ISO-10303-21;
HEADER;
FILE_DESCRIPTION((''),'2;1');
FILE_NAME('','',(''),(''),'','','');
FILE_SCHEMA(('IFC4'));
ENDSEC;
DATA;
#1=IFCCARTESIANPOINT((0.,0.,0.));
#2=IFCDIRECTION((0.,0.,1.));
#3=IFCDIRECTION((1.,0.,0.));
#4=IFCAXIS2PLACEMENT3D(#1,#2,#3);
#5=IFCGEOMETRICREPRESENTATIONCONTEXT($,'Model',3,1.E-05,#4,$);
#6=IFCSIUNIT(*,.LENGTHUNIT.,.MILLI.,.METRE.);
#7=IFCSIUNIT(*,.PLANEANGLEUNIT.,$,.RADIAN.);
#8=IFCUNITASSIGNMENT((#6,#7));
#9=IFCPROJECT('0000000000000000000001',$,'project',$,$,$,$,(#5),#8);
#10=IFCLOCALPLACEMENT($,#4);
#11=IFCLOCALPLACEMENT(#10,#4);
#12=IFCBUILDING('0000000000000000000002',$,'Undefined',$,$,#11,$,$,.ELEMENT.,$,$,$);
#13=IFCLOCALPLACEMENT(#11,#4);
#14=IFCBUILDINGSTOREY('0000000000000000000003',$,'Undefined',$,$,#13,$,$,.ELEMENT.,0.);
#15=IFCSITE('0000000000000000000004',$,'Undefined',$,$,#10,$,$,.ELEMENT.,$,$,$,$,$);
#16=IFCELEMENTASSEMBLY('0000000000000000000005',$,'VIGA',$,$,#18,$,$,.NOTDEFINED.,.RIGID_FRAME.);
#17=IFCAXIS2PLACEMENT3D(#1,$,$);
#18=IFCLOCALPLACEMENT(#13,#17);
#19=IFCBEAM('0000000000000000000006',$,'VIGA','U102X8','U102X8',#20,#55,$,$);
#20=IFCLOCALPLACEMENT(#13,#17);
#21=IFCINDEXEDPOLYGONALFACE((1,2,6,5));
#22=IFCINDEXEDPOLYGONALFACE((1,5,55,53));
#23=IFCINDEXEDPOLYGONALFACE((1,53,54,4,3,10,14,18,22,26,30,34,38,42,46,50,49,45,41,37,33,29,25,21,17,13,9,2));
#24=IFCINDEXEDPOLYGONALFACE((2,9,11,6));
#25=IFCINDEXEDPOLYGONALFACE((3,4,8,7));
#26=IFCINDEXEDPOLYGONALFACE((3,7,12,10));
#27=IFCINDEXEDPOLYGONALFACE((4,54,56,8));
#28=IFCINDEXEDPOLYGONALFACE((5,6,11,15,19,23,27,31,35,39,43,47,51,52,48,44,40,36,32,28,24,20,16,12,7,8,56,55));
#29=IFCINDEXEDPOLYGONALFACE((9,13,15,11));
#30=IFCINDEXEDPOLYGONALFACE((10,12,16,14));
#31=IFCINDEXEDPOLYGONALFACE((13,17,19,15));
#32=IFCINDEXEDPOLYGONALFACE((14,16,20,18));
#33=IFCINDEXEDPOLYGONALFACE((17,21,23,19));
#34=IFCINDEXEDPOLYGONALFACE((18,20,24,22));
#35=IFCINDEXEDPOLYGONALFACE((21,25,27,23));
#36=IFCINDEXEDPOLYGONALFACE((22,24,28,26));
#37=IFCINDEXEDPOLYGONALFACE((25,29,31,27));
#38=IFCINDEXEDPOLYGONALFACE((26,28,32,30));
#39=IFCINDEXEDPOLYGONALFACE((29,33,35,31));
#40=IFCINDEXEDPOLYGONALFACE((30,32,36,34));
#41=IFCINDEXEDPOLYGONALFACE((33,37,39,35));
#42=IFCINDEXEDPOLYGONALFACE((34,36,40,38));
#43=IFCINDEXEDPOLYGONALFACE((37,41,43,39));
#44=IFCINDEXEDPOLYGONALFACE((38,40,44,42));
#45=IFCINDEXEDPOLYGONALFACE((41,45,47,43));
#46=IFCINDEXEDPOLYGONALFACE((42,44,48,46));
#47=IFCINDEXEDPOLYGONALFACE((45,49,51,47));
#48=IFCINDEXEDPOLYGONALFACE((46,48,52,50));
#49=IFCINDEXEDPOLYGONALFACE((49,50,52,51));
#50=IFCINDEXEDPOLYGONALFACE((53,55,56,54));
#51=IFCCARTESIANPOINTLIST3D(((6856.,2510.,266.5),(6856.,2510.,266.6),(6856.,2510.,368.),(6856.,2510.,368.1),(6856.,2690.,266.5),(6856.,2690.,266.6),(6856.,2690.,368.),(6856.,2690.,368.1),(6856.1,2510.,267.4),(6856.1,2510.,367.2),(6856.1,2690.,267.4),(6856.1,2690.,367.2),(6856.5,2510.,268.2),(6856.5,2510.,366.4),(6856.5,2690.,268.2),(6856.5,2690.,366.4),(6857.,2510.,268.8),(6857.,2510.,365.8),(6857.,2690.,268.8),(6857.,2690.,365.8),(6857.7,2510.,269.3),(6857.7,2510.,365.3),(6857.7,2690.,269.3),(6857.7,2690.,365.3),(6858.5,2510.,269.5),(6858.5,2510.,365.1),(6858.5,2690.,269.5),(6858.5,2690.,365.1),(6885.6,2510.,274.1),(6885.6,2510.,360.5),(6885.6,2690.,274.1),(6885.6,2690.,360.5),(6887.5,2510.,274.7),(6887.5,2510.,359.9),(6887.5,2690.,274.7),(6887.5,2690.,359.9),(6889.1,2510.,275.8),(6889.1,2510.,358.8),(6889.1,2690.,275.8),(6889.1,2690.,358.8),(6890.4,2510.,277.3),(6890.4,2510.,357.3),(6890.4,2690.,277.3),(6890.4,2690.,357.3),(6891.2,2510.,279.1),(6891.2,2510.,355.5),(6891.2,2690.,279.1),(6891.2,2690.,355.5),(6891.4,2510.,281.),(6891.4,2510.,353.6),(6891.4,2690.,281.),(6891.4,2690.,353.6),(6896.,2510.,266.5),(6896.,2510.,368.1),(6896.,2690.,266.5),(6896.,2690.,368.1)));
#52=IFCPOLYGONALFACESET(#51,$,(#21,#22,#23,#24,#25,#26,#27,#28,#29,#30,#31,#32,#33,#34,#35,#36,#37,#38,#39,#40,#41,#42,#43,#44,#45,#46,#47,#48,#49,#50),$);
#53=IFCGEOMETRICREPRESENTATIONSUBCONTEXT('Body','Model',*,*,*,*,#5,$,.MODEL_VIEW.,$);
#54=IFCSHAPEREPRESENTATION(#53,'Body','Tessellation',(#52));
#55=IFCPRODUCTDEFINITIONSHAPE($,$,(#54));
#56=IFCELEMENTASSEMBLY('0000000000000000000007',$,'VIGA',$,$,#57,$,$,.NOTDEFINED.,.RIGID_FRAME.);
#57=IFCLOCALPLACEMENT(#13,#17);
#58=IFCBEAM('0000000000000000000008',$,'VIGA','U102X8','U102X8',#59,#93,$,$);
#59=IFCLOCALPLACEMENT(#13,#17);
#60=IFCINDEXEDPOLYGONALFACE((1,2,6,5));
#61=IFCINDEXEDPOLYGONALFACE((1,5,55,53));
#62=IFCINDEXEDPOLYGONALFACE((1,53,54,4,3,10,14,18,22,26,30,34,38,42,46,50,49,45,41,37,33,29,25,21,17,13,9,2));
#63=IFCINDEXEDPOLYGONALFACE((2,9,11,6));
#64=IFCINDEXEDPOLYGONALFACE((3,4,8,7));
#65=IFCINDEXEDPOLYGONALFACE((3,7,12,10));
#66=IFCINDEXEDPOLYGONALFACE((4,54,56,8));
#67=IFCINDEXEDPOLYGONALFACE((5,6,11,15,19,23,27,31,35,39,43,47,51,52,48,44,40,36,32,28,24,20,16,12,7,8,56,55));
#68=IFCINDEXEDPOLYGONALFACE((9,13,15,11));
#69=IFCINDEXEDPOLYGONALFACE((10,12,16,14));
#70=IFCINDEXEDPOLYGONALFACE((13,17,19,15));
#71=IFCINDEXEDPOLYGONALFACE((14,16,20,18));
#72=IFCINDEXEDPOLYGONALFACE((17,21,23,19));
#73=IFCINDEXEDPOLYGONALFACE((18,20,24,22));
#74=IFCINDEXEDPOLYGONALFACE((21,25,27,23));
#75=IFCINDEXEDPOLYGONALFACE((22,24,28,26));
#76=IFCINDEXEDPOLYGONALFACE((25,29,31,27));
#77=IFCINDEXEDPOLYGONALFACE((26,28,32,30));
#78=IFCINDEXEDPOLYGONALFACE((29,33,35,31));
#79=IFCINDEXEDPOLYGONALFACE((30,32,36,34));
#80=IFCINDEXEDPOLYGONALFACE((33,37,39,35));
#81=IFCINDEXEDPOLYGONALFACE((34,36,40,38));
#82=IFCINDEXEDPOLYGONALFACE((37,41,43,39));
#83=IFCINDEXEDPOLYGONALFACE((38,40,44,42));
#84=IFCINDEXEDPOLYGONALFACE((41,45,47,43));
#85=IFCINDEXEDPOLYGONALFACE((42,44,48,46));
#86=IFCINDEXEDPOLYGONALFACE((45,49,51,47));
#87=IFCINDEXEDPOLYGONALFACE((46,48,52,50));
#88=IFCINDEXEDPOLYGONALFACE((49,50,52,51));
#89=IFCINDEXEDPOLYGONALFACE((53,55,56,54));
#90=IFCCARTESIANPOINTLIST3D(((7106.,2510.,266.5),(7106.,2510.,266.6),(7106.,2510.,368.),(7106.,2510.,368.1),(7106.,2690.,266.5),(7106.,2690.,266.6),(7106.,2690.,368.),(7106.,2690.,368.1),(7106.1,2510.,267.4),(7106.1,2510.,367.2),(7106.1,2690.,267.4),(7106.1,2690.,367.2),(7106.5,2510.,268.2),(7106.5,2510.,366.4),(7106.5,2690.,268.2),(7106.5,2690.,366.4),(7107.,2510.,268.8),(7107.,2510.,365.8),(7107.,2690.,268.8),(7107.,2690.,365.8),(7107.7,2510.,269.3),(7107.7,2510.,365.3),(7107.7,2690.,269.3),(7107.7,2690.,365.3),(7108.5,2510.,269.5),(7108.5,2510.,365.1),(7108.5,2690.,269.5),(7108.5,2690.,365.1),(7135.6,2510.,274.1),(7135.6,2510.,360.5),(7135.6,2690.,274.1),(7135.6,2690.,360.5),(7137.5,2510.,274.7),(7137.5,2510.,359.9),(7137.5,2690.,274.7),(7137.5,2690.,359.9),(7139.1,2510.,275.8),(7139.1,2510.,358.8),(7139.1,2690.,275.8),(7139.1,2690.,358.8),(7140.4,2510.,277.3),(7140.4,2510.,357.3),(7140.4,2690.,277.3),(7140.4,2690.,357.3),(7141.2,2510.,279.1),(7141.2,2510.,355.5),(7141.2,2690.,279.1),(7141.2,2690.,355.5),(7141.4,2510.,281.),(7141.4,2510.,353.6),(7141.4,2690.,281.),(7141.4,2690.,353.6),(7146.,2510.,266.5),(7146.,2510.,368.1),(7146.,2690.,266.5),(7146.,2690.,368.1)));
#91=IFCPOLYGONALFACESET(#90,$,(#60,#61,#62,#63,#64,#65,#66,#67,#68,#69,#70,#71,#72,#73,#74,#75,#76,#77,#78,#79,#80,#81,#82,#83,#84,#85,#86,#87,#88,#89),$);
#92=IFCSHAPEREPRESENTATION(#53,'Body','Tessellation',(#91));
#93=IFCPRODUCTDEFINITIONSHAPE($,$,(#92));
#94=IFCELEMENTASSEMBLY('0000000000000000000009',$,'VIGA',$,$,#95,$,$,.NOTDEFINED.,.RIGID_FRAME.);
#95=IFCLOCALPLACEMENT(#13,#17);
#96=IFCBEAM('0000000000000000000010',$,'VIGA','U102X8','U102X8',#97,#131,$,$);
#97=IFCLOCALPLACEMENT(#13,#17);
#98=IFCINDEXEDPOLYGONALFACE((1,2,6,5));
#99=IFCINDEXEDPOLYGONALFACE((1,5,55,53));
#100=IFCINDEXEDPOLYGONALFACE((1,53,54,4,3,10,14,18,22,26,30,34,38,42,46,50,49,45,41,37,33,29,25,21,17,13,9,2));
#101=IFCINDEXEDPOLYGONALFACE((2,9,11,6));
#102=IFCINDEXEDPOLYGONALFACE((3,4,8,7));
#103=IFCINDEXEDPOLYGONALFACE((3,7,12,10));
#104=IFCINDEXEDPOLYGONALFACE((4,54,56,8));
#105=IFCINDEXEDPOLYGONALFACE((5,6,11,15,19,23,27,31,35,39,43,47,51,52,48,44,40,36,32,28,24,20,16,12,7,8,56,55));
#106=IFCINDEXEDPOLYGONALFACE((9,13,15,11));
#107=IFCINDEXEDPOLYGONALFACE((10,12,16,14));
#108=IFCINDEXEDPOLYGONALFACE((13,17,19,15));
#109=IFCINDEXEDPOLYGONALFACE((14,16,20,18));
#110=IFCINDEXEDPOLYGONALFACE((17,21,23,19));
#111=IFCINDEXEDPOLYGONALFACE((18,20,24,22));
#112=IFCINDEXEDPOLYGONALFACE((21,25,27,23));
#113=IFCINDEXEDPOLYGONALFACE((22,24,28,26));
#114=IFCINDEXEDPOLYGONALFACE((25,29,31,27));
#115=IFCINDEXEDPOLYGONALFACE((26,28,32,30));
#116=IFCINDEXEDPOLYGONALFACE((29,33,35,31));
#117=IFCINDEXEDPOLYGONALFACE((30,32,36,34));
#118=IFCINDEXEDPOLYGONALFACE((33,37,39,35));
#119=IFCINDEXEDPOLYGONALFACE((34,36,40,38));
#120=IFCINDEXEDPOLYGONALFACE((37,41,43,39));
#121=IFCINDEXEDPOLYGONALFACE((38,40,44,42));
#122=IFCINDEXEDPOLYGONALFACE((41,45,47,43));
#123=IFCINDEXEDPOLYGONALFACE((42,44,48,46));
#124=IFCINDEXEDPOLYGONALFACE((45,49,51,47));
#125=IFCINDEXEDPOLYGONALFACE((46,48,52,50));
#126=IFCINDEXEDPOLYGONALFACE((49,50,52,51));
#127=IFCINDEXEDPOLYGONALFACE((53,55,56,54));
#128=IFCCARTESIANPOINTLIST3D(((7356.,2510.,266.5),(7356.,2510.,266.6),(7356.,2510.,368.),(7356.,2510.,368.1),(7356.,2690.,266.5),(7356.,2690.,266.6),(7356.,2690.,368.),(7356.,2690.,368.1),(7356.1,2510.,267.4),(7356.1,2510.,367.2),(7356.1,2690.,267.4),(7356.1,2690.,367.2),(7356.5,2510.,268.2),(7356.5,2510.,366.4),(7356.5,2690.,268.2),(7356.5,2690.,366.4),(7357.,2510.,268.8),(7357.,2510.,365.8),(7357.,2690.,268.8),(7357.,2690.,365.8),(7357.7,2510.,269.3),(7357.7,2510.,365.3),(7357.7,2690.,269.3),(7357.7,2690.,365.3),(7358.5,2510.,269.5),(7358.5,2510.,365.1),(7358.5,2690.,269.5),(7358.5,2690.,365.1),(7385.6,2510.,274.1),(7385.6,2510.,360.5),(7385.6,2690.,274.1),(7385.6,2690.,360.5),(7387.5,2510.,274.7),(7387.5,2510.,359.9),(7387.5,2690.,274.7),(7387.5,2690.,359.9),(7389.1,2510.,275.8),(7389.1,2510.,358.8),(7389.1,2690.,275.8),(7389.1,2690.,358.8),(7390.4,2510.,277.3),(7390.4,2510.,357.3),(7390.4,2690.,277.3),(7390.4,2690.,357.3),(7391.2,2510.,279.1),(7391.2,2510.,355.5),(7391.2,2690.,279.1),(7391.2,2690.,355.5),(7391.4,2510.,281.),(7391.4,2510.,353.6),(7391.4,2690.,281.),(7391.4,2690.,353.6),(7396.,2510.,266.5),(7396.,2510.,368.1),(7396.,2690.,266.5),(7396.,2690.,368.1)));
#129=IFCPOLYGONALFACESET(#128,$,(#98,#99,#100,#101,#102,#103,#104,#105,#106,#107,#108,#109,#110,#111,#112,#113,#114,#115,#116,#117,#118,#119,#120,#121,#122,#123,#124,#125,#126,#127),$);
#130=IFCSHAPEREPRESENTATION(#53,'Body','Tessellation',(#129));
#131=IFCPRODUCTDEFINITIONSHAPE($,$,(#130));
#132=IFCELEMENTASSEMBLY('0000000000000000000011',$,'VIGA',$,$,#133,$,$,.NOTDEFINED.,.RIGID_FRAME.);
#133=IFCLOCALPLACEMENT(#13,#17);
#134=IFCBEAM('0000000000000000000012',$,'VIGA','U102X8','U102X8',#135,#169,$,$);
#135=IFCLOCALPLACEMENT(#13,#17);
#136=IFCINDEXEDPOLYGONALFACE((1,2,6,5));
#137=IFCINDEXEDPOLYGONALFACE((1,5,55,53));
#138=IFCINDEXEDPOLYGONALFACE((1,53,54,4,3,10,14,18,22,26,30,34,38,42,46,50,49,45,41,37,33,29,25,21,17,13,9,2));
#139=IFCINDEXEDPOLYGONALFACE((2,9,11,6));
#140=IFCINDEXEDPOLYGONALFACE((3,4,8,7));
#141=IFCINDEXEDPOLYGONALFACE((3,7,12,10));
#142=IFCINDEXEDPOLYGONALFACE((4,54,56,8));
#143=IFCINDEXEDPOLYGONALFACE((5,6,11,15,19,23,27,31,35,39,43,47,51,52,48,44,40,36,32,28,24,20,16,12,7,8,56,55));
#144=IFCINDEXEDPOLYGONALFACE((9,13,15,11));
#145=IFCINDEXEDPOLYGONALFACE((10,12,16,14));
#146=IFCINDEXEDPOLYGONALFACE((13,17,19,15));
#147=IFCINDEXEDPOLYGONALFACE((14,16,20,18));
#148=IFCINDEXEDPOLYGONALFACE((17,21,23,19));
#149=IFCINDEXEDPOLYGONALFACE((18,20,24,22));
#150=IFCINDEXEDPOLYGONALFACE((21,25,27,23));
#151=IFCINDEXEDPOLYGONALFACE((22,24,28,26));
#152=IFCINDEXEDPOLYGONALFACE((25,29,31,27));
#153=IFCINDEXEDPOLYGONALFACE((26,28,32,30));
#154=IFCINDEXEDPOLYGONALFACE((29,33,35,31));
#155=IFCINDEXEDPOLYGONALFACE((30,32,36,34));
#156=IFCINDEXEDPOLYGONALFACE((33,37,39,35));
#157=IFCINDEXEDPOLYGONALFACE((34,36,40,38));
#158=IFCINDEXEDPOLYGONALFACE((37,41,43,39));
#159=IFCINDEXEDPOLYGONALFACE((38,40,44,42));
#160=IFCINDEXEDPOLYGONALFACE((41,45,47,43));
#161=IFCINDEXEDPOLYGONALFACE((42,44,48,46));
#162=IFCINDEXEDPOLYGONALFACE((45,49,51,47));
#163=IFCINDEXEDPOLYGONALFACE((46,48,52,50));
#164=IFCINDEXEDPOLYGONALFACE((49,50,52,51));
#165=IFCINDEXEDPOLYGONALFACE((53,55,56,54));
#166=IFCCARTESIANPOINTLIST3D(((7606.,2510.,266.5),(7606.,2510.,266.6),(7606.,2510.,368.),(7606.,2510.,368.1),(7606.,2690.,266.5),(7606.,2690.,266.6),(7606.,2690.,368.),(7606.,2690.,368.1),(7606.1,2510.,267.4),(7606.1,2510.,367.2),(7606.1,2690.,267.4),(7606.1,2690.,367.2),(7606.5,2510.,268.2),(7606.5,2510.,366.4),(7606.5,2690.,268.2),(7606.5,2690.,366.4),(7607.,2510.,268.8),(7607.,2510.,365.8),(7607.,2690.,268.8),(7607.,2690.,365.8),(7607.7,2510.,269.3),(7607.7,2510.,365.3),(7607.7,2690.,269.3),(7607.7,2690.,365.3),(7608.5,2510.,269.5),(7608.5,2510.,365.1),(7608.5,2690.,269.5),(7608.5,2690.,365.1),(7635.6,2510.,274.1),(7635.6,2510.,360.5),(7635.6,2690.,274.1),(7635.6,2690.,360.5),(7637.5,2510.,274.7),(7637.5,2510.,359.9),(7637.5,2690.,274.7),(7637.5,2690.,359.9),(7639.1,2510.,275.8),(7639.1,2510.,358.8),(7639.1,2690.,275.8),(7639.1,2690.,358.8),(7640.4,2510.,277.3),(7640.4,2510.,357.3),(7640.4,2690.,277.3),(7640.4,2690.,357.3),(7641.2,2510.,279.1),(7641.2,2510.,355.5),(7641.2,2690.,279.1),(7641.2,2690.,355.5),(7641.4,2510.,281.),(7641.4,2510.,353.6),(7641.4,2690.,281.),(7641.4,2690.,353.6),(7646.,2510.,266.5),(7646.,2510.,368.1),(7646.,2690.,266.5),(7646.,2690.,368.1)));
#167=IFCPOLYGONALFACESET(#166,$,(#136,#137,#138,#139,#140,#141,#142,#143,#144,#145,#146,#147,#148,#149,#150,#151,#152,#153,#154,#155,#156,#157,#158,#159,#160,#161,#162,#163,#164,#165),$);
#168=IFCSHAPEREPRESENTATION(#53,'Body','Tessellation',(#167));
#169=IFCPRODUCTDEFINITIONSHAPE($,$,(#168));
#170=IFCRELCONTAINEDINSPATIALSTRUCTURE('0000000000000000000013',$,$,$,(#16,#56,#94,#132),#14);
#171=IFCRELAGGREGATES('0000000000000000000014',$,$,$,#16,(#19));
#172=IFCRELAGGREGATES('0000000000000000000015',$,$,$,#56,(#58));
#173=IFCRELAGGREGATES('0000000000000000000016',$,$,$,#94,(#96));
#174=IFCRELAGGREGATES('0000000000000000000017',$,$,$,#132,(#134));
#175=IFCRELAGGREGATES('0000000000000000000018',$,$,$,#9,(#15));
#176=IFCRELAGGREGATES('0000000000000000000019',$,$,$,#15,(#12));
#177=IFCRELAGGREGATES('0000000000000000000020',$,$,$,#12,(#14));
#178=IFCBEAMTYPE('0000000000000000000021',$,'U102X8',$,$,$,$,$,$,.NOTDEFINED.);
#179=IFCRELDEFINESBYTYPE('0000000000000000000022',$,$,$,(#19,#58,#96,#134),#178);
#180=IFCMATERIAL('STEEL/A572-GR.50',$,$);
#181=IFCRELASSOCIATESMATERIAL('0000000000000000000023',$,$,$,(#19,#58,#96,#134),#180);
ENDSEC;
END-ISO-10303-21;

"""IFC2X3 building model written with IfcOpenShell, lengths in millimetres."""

from ifc_helpers import new_model, si_unit, frame, origin_with_axes, origin_2d_with_axis, place, context, subcontext, project, spatial, u_section, extrude, material, type_object, element, aggregate, save


model = new_model("IFC2X3")

# Units and contexts
model_context = context("Model", 3, precision=1e-05, world=origin_with_axes())
body_context = subcontext(model_context, "Body", "Model", "MODEL_VIEW")
ifc_project = project(units=[si_unit("LENGTHUNIT", "METRE", prefix="MILLI"), si_unit("PLANEANGLEUNIT", "RADIAN")], contexts=[model_context])

# Site, building, storey
site_placement = place(None, origin_with_axes())
site = spatial("IfcSite", under=ifc_project, at=site_placement, Name="Undefined", CompositionType="ELEMENT")
building_placement = place(site_placement, origin_with_axes())
building = spatial("IfcBuilding", under=site, at=building_placement, Name="Undefined", CompositionType="ELEMENT")
storey_placement = place(building_placement, origin_with_axes())
storey = spatial("IfcBuildingStorey", under=building, at=storey_placement, Name="Undefined", CompositionType="ELEMENT", Elevation=0.0)

# Element assemblies, beams
ifc_material_1 = material(Name="STEEL/A572-GR.50")
beam_type_1 = type_object("IfcBeamType", Name="U102X8", PredefinedType="NOTDEFINED")
assembly_1_placement = place(storey_placement, origin_with_axes())
assembly_1 = element("IfcElementAssembly", 1, at=assembly_1_placement, inside=storey, Name="VIGA", AssemblyPlace="NOTDEFINED", PredefinedType="RIGID_FRAME")
beam_1_placement = place(assembly_1_placement, frame((6876.0, 2690.0, 317.3), z_axis=(0.0, 0.0, 1.0), x_axis=(0.0, -1.0, 0.0)))
beam_1 = element("IfcBeam", 2, at=beam_1_placement, type_object=beam_type_1, material=ifc_material_1, Name="VIGA", Description="U102X8", ObjectType="U102X8", context=body_context, shape_type="SweptSolid", body=[
    extrude(u_section(Depth=101.6, FlangeWidth=40.0, WebThickness=4.6, FlangeThickness=6.0, FilletRadius=7.0, EdgeRadius=3.0, FlangeSlope=0.16839, at=origin_2d_with_axis()), frame((180.0, 0.0, 0.0), z_axis=(-1.0, 0.0, 0.0), x_axis=(0.0, -1.0, 0.0)), (0.0, 0.0, 1.0), 180.0),
])
aggregate(assembly_1, [beam_1])
assembly_2_placement = place(storey_placement, origin_with_axes())
assembly_2 = element("IfcElementAssembly", 3, at=assembly_2_placement, inside=storey, Name="VIGA", AssemblyPlace="NOTDEFINED", PredefinedType="RIGID_FRAME")
beam_2_placement = place(assembly_2_placement, frame((7126.0, 2690.0, 317.3), z_axis=(0.0, 0.0, 1.0), x_axis=(0.0, -1.0, 0.0)))
beam_2 = element("IfcBeam", 4, at=beam_2_placement, type_object=beam_type_1, material=ifc_material_1, Name="VIGA", Description="U102X8", ObjectType="U102X8", context=body_context, shape_type="SweptSolid", body=[
    extrude(u_section(Depth=101.6, FlangeWidth=40.0, WebThickness=4.6, FlangeThickness=6.0, FilletRadius=7.0, EdgeRadius=3.0, FlangeSlope=0.16839, at=origin_2d_with_axis()), frame((180.0, 0.0, 0.0), z_axis=(-1.0, 0.0, 0.0), x_axis=(0.0, -1.0, 0.0)), (0.0, 0.0, 1.0), 180.0),
])
aggregate(assembly_2, [beam_2])
assembly_3_placement = place(storey_placement, origin_with_axes())
assembly_3 = element("IfcElementAssembly", 5, at=assembly_3_placement, inside=storey, Name="VIGA", AssemblyPlace="NOTDEFINED", PredefinedType="RIGID_FRAME")
beam_3_placement = place(assembly_3_placement, frame((7376.0, 2690.0, 317.3), z_axis=(0.0, 0.0, 1.0), x_axis=(0.0, -1.0, 0.0)))
beam_3 = element("IfcBeam", 6, at=beam_3_placement, type_object=beam_type_1, material=ifc_material_1, Name="VIGA", Description="U102X8", ObjectType="U102X8", context=body_context, shape_type="SweptSolid", body=[
    extrude(u_section(Depth=101.6, FlangeWidth=40.0, WebThickness=4.6, FlangeThickness=6.0, FilletRadius=7.0, EdgeRadius=3.0, FlangeSlope=0.16839, at=origin_2d_with_axis()), frame((180.0, 0.0, 0.0), z_axis=(-1.0, 0.0, 0.0), x_axis=(0.0, -1.0, 0.0)), (0.0, 0.0, 1.0), 180.0),
])
aggregate(assembly_3, [beam_3])
assembly_4_placement = place(storey_placement, origin_with_axes())
assembly_4 = element("IfcElementAssembly", 7, at=assembly_4_placement, inside=storey, Name="VIGA", AssemblyPlace="NOTDEFINED", PredefinedType="RIGID_FRAME")
beam_4_placement = place(assembly_4_placement, frame((7626.0, 2690.0, 317.3), z_axis=(0.0, 0.0, 1.0), x_axis=(0.0, -1.0, 0.0)))
beam_4 = element("IfcBeam", 8, at=beam_4_placement, type_object=beam_type_1, material=ifc_material_1, Name="VIGA", Description="U102X8", ObjectType="U102X8", context=body_context, shape_type="SweptSolid", body=[
    extrude(u_section(Depth=101.6, FlangeWidth=40.0, WebThickness=4.6, FlangeThickness=6.0, FilletRadius=7.0, EdgeRadius=3.0, FlangeSlope=0.16839, at=origin_2d_with_axis()), frame((180.0, 0.0, 0.0), z_axis=(-1.0, 0.0, 0.0), x_axis=(0.0, -1.0, 0.0)), (0.0, 0.0, 1.0), 180.0),
])
aggregate(assembly_4, [beam_4])

save(model, "model.ifc")
